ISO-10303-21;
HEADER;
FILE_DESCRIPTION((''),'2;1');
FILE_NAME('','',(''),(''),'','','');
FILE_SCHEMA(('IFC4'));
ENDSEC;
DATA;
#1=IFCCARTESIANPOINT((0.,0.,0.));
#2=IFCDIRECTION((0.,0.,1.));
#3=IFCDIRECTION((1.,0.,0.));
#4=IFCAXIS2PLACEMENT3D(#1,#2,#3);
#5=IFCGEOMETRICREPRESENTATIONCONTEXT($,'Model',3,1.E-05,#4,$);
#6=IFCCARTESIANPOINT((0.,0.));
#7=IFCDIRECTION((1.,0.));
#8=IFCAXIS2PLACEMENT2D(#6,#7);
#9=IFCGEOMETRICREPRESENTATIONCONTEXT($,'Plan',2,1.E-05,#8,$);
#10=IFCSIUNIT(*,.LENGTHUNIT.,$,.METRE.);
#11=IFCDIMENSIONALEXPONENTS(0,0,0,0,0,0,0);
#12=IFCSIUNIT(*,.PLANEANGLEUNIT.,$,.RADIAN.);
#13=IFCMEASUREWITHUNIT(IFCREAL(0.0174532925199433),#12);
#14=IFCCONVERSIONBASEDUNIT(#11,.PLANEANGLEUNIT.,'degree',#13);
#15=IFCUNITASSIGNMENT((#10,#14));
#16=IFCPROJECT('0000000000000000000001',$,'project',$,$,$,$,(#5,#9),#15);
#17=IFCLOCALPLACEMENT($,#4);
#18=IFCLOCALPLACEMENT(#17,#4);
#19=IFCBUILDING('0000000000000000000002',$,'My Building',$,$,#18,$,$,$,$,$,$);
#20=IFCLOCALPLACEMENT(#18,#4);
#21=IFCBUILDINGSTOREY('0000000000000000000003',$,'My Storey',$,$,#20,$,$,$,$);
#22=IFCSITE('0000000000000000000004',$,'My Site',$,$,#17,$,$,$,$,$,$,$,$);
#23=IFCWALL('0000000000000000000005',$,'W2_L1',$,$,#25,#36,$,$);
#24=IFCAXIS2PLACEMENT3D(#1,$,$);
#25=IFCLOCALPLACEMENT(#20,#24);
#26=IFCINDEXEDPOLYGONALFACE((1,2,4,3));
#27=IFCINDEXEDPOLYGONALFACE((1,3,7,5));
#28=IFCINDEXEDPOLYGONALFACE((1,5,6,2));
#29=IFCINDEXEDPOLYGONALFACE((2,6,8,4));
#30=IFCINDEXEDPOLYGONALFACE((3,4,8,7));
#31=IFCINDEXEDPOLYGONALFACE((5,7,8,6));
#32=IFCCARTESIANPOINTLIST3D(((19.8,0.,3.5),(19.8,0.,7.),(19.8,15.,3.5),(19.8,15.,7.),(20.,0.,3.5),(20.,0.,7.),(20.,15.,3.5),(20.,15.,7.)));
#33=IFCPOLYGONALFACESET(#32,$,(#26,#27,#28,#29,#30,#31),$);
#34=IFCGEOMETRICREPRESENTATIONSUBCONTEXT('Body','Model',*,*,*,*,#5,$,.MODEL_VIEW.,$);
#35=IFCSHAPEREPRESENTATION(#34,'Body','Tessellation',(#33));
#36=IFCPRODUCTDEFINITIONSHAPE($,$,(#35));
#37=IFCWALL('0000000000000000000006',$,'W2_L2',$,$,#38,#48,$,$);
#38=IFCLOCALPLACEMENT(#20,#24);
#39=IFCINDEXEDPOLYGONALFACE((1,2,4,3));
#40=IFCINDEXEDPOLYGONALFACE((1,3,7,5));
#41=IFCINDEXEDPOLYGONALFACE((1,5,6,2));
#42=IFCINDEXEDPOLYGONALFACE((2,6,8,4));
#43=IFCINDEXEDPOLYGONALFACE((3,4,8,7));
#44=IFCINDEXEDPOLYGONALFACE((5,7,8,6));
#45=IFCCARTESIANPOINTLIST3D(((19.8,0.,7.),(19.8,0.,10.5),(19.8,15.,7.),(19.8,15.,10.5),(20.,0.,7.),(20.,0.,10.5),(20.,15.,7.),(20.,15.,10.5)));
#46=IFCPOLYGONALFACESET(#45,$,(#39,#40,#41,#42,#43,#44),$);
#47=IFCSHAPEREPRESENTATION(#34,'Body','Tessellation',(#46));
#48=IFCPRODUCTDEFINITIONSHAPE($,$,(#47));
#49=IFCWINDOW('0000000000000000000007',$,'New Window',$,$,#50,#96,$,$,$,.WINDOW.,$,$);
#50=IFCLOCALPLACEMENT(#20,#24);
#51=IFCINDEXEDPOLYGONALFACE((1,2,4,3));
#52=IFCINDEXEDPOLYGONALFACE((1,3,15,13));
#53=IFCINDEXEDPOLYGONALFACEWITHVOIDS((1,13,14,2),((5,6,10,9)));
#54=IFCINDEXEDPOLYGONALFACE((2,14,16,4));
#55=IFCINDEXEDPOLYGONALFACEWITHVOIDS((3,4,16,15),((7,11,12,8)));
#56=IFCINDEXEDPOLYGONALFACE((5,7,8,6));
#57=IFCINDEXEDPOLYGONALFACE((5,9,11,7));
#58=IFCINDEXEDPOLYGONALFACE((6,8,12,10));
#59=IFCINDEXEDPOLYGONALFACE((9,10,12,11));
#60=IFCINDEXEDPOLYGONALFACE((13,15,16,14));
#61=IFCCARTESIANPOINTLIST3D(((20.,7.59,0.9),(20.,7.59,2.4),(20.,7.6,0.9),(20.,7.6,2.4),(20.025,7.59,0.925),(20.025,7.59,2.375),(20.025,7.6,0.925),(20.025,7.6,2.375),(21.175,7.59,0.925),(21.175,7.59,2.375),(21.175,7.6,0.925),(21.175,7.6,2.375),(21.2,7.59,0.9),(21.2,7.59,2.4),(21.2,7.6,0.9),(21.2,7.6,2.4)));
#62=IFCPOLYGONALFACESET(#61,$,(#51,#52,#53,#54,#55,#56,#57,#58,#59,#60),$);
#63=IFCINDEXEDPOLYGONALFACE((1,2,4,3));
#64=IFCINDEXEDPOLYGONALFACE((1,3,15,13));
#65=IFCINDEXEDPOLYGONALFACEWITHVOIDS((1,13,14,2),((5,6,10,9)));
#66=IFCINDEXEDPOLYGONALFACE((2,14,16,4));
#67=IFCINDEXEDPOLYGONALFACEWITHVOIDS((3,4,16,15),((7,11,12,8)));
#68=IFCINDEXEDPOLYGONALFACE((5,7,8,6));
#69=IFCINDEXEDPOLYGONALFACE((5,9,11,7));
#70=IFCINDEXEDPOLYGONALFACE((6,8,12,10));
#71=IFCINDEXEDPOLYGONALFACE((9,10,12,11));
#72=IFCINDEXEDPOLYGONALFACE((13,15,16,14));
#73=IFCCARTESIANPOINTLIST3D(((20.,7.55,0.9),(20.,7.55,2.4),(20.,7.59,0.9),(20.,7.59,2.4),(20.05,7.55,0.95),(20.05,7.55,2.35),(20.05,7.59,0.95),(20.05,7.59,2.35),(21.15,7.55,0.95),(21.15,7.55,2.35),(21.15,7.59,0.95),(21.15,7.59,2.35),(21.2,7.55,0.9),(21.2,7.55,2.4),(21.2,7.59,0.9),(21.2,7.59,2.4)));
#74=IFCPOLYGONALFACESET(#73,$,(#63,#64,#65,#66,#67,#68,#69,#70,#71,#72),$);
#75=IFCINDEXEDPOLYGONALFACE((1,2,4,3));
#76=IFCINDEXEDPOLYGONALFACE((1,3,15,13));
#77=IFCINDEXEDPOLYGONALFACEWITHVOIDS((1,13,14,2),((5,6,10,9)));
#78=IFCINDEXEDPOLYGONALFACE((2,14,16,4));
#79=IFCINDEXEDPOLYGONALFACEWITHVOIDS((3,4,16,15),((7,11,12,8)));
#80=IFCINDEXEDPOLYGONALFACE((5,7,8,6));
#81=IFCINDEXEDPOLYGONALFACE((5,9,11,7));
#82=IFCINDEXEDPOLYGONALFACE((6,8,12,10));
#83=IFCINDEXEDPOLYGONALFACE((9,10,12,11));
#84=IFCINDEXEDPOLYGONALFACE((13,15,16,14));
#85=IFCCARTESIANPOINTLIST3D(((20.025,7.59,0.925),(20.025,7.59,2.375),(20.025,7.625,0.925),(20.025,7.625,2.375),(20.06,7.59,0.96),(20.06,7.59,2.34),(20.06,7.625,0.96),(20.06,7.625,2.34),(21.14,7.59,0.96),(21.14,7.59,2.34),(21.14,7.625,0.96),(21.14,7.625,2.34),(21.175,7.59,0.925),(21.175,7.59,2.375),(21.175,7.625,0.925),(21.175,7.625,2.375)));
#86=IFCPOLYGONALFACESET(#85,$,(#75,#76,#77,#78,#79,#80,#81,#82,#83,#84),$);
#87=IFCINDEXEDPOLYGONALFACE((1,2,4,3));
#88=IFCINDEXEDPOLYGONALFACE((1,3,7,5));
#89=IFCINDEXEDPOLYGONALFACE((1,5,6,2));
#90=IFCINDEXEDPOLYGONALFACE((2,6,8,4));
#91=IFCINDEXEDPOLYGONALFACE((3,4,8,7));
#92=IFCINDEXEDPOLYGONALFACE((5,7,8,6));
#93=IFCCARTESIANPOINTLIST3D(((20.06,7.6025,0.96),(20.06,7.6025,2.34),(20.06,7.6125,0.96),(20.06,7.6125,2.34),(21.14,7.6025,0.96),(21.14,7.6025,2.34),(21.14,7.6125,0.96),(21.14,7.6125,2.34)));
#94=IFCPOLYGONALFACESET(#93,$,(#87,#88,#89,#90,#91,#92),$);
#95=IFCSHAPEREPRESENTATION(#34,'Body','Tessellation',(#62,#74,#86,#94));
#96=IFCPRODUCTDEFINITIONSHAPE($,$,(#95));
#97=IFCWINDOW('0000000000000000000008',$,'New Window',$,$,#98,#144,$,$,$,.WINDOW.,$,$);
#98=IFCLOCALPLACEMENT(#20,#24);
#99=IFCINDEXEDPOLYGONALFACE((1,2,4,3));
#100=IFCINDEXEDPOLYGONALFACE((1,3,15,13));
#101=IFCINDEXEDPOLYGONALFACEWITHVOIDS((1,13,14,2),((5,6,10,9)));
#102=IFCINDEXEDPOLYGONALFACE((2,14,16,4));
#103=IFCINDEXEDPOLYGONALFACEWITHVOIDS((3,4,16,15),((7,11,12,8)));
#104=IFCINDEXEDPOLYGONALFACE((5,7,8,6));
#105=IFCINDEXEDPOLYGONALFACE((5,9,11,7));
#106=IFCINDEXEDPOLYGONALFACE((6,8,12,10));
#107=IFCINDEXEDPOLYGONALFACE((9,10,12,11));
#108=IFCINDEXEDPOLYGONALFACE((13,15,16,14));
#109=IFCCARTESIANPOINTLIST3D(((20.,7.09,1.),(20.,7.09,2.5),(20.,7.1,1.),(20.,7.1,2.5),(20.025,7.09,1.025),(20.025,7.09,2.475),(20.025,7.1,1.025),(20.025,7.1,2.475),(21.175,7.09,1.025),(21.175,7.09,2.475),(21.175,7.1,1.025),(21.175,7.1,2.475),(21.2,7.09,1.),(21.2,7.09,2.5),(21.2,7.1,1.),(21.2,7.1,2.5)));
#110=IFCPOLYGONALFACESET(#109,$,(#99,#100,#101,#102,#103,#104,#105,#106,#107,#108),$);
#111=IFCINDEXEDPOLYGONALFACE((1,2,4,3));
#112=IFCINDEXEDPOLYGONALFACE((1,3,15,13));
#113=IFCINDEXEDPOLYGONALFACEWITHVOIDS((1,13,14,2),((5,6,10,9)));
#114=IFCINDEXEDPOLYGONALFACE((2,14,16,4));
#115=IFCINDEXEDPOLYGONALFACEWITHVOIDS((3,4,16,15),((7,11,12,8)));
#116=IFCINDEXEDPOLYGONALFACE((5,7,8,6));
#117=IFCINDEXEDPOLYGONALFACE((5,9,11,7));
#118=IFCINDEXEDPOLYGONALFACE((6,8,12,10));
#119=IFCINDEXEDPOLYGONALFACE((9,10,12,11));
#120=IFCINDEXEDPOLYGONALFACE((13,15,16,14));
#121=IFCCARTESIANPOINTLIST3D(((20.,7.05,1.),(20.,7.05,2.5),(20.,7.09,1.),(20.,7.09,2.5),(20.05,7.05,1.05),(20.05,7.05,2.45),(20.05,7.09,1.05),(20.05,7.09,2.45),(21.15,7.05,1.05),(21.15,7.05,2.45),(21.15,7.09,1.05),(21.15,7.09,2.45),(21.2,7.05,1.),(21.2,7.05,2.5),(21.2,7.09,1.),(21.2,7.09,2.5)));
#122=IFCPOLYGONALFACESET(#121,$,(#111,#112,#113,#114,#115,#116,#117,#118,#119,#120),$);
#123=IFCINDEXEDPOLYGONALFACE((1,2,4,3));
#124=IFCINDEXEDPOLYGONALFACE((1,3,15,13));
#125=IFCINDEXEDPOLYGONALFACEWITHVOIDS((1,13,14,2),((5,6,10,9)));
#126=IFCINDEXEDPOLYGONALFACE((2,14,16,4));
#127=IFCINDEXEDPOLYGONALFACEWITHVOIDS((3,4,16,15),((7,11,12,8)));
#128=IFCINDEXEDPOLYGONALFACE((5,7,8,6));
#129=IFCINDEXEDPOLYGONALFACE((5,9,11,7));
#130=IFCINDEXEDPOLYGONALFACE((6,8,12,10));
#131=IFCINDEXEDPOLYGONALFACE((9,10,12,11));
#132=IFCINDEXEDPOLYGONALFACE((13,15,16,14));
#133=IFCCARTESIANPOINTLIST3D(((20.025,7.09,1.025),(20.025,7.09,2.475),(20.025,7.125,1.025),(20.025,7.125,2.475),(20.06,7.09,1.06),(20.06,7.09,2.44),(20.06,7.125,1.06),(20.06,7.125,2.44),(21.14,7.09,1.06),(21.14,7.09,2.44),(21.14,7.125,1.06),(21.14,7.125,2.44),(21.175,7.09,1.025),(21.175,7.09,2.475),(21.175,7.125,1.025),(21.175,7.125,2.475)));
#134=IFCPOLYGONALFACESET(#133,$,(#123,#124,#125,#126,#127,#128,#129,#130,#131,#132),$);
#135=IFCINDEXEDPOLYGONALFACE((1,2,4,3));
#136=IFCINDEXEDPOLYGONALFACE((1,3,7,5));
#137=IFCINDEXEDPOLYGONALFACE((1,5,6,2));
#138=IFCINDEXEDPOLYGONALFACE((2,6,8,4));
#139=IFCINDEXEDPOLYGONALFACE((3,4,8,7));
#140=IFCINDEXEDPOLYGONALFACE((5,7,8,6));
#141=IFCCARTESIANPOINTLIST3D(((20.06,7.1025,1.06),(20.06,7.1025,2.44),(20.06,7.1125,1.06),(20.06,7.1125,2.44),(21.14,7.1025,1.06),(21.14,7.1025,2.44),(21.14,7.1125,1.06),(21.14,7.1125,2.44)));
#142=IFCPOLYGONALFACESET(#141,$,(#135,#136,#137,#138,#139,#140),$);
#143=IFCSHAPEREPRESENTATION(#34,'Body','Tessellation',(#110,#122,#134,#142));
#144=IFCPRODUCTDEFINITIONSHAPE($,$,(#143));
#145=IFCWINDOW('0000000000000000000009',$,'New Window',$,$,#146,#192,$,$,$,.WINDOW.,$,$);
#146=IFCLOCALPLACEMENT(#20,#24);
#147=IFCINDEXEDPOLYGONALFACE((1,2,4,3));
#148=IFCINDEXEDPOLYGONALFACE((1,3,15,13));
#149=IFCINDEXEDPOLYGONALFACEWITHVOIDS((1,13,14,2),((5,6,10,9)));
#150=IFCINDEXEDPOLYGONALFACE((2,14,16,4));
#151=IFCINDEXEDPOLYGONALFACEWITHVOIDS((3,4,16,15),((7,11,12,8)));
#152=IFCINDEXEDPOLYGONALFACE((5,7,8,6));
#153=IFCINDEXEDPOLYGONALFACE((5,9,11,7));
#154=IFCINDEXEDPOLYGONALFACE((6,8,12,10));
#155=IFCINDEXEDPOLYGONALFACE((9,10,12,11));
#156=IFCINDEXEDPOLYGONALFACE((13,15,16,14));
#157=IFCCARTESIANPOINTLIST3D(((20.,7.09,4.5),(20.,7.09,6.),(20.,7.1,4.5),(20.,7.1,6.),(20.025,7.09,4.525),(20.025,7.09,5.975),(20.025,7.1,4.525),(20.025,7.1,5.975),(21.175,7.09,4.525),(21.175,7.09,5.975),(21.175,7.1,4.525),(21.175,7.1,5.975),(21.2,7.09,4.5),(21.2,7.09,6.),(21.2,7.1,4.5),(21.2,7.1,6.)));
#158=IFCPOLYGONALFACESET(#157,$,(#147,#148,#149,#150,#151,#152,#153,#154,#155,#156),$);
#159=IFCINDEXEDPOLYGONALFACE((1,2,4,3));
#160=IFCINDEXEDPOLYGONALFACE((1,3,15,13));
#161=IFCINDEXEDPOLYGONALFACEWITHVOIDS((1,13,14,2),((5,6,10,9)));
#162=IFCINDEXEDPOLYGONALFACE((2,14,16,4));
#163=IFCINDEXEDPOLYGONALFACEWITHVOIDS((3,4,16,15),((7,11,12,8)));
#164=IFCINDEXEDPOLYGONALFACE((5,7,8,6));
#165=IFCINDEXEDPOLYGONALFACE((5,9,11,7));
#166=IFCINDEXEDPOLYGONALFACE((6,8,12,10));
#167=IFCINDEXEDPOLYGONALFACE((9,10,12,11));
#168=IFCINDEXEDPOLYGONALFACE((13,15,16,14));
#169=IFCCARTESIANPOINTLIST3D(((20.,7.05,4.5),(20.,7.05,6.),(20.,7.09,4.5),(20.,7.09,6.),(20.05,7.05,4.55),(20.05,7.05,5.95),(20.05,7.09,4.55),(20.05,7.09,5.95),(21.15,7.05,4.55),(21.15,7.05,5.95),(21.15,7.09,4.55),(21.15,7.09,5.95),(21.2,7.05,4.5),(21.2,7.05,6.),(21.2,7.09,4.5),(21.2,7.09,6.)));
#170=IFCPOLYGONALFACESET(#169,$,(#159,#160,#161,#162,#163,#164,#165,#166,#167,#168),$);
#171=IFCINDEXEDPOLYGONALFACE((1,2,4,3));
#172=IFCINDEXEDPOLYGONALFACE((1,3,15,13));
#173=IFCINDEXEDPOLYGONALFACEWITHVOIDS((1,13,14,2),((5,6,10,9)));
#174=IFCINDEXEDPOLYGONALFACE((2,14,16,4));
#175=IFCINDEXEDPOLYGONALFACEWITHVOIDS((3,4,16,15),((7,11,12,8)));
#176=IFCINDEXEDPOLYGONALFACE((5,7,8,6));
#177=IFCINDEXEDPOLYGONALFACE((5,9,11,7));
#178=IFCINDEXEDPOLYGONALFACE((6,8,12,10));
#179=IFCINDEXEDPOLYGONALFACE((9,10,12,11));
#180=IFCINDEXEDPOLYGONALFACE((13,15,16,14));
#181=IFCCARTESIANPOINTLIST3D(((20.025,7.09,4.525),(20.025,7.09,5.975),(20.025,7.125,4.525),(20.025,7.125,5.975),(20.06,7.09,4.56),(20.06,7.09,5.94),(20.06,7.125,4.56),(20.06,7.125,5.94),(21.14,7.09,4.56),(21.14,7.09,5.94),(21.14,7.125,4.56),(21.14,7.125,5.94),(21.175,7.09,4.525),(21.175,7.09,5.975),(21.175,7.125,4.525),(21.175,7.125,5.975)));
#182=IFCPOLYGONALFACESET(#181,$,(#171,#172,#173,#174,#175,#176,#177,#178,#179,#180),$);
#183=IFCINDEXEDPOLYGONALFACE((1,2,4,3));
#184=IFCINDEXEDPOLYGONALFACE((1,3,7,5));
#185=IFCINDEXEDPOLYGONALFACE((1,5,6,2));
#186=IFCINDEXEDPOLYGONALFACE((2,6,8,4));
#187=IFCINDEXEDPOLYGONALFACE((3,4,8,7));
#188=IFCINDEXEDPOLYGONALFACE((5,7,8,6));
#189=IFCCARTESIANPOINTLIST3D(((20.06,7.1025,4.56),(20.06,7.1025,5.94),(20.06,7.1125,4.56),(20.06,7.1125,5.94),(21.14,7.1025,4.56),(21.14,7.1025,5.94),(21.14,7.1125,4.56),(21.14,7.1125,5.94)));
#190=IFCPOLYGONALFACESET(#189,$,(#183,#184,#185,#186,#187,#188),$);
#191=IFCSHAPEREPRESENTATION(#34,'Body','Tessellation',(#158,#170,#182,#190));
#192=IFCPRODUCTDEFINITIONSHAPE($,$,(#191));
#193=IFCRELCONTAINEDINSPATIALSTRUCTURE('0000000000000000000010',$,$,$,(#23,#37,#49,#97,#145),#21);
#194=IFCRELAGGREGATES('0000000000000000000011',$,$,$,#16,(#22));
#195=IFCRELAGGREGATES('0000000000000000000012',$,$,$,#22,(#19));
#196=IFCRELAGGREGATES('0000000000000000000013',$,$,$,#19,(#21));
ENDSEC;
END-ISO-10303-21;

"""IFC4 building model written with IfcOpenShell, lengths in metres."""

from ifc_helpers import new_model, entity, si_unit, converted_unit, frame, origin_with_axes, origin_2d_with_axis, place, context, subcontext, project, spatial, line, indexed_curve, outline, extrude, element, save


model = new_model("IFC4")

# Units and contexts
model_context = context("Model", 3, precision=1e-05, world=origin_with_axes())
plan_context = context("Plan", 2, precision=1e-05, world=origin_2d_with_axis())
body_context = subcontext(model_context, "Body", "Model", "MODEL_VIEW")
ifc_project = project(units=[si_unit("LENGTHUNIT", "METRE"), converted_unit("PLANEANGLEUNIT", "degree", entity("IfcReal", 0.0174532925199433), si_unit("PLANEANGLEUNIT", "RADIAN"), dimensions=[0, 0, 0, 0, 0, 0, 0])], contexts=[model_context, plan_context])

# Site, building, storey
site_placement = place(None, origin_with_axes())
site = spatial("IfcSite", under=ifc_project, at=site_placement, Name="My Site")
building_placement = place(site_placement, origin_with_axes())
building = spatial("IfcBuilding", under=site, at=building_placement, Name="My Building")
storey_placement = place(building_placement, origin_with_axes())
storey = spatial("IfcBuildingStorey", under=building, at=storey_placement, Name="My Storey")

# Walls
for number, where, z_axis, x_axis, name in (
    (1, (20.0, 0.0, 3.5), (0.0, 0.0, 1.0), (0.0, 1.0, 0.0), "W2_L1"),
    (2, (20.0, 0.0, 7.0), (0.0, 0.0, 1.0), (0.0, 1.0, 0.0), "W2_L2"),
):
    element("IfcWall", number, at=place(storey_placement, frame(where, z_axis=z_axis, x_axis=x_axis)), inside=storey, Name=name, context=body_context, shape_type="SweptSolid", body=[
        extrude(outline(indexed_curve([(0.0, 0.0), (0.0, 0.2), (15.0, 0.2), (15.0, 0.0), (0.0, 0.0)], self_intersect=False)), origin_with_axes(), (0.0, 0.0, 1.0), 3.5),
    ])

# Window
window_1_placement = place(storey_placement, frame((20.0, 7.5, 0.9), z_axis=(0.0, 0.0, 1.0), x_axis=(1.0, 0.0, 0.0)))
element("IfcWindow", 3, at=window_1_placement, inside=storey, Name="New Window", PredefinedType="WINDOW", context=body_context, shape_type="SweptSolid", body=[
    extrude(outline(indexed_curve([(0.0, 0.0), (1.2, 0.0), (1.2, 1.5), (0.0, 1.5)], segments=[line(1, 2, 3, 4, 1)]), holes=[indexed_curve([(0.025, 0.025), (1.175, 0.025), (1.175, 1.475), (0.025, 1.475)], segments=[line(1, 2, 3, 4, 1)])]), frame((0.0, 0.09, 0.0), z_axis=(0.0, -1.0, 0.0), x_axis=(1.0, 0.0, 0.0)), (0.0, 0.0, -1.0), 0.01),
    extrude(outline(indexed_curve([(0.0, 0.0), (1.2, 0.0), (1.2, 1.5), (0.0, 1.5)], segments=[line(1, 2, 3, 4, 1)]), holes=[indexed_curve([(0.05, 0.05), (1.15, 0.05), (1.15, 1.45), (0.05, 1.45)], segments=[line(1, 2, 3, 4, 1)])]), frame((0.0, 0.05, 0.0), z_axis=(0.0, -1.0, 0.0), x_axis=(1.0, 0.0, 0.0)), (0.0, 0.0, -1.0), 0.04),
    extrude(outline(indexed_curve([(0.0, 0.0), (1.15, 0.0), (1.15, 1.45), (0.0, 1.45)], segments=[line(1, 2, 3, 4, 1)]), holes=[indexed_curve([(0.035, 0.035), (1.115, 0.035), (1.115, 1.415), (0.035, 1.415)], segments=[line(1, 2, 3, 4, 1)])]), frame((0.025, 0.09, 0.025), z_axis=(0.0, -1.0, 0.0), x_axis=(1.0, 0.0, 0.0)), (0.0, 0.0, -1.0), 0.035),
    extrude(outline(indexed_curve([(0.035, 0.035), (1.115, 0.035), (1.115, 1.415), (0.035, 1.415)], segments=[line(1, 2, 3, 4, 1)])), frame((0.025, 0.1025, 0.025), z_axis=(0.0, -1.0, 0.0), x_axis=(1.0, 0.0, 0.0)), (0.0, 0.0, -1.0), 0.01),
])

# Windows
for number, where, z_axis, x_axis, name in (
    (4, (20.0, 7.0, 1.0), (0.0, 0.0, 1.0), (1.0, 0.0, 0.0), "New Window"),
    (5, (20.0, 7.0, 4.5), (0.0, 0.0, 1.0), (1.0, 0.0, 0.0), "New Window"),
):
    element("IfcWindow", number, at=place(storey_placement, frame(where, z_axis=z_axis, x_axis=x_axis)), inside=storey, Name=name, PredefinedType="WINDOW", context=body_context, shape_type="SweptSolid", body=[
        extrude(outline(indexed_curve([(0.0, 0.0), (1.2, 0.0), (1.2, 1.5), (0.0, 1.5)], segments=[line(1, 2, 3, 4, 1)]), holes=[indexed_curve([(0.025, 0.025), (1.175, 0.025), (1.175, 1.475), (0.025, 1.475)], segments=[line(1, 2, 3, 4, 1)])]), frame((0.0, 0.09, 0.0), z_axis=(0.0, -1.0, 0.0), x_axis=(1.0, 0.0, 0.0)), (0.0, 0.0, -1.0), 0.01),
        extrude(outline(indexed_curve([(0.0, 0.0), (1.2, 0.0), (1.2, 1.5), (0.0, 1.5)], segments=[line(1, 2, 3, 4, 1)]), holes=[indexed_curve([(0.05, 0.05), (1.15, 0.05), (1.15, 1.45), (0.05, 1.45)], segments=[line(1, 2, 3, 4, 1)])]), frame((0.0, 0.05, 0.0), z_axis=(0.0, -1.0, 0.0), x_axis=(1.0, 0.0, 0.0)), (0.0, 0.0, -1.0), 0.04),
        extrude(outline(indexed_curve([(0.0, 0.0), (1.15, 0.0), (1.15, 1.45), (0.0, 1.45)], segments=[line(1, 2, 3, 4, 1)]), holes=[indexed_curve([(0.035, 0.035), (1.115, 0.035), (1.115, 1.415), (0.035, 1.415)], segments=[line(1, 2, 3, 4, 1)])]), frame((0.025, 0.09, 0.025), z_axis=(0.0, -1.0, 0.0), x_axis=(1.0, 0.0, 0.0)), (0.0, 0.0, -1.0), 0.035),
        extrude(outline(indexed_curve([(0.035, 0.035), (1.115, 0.035), (1.115, 1.415), (0.035, 1.415)], segments=[line(1, 2, 3, 4, 1)])), frame((0.025, 0.1025, 0.025), z_axis=(0.0, -1.0, 0.0), x_axis=(1.0, 0.0, 0.0)), (0.0, 0.0, -1.0), 0.01),
    ])

save(model, "model.ifc")
